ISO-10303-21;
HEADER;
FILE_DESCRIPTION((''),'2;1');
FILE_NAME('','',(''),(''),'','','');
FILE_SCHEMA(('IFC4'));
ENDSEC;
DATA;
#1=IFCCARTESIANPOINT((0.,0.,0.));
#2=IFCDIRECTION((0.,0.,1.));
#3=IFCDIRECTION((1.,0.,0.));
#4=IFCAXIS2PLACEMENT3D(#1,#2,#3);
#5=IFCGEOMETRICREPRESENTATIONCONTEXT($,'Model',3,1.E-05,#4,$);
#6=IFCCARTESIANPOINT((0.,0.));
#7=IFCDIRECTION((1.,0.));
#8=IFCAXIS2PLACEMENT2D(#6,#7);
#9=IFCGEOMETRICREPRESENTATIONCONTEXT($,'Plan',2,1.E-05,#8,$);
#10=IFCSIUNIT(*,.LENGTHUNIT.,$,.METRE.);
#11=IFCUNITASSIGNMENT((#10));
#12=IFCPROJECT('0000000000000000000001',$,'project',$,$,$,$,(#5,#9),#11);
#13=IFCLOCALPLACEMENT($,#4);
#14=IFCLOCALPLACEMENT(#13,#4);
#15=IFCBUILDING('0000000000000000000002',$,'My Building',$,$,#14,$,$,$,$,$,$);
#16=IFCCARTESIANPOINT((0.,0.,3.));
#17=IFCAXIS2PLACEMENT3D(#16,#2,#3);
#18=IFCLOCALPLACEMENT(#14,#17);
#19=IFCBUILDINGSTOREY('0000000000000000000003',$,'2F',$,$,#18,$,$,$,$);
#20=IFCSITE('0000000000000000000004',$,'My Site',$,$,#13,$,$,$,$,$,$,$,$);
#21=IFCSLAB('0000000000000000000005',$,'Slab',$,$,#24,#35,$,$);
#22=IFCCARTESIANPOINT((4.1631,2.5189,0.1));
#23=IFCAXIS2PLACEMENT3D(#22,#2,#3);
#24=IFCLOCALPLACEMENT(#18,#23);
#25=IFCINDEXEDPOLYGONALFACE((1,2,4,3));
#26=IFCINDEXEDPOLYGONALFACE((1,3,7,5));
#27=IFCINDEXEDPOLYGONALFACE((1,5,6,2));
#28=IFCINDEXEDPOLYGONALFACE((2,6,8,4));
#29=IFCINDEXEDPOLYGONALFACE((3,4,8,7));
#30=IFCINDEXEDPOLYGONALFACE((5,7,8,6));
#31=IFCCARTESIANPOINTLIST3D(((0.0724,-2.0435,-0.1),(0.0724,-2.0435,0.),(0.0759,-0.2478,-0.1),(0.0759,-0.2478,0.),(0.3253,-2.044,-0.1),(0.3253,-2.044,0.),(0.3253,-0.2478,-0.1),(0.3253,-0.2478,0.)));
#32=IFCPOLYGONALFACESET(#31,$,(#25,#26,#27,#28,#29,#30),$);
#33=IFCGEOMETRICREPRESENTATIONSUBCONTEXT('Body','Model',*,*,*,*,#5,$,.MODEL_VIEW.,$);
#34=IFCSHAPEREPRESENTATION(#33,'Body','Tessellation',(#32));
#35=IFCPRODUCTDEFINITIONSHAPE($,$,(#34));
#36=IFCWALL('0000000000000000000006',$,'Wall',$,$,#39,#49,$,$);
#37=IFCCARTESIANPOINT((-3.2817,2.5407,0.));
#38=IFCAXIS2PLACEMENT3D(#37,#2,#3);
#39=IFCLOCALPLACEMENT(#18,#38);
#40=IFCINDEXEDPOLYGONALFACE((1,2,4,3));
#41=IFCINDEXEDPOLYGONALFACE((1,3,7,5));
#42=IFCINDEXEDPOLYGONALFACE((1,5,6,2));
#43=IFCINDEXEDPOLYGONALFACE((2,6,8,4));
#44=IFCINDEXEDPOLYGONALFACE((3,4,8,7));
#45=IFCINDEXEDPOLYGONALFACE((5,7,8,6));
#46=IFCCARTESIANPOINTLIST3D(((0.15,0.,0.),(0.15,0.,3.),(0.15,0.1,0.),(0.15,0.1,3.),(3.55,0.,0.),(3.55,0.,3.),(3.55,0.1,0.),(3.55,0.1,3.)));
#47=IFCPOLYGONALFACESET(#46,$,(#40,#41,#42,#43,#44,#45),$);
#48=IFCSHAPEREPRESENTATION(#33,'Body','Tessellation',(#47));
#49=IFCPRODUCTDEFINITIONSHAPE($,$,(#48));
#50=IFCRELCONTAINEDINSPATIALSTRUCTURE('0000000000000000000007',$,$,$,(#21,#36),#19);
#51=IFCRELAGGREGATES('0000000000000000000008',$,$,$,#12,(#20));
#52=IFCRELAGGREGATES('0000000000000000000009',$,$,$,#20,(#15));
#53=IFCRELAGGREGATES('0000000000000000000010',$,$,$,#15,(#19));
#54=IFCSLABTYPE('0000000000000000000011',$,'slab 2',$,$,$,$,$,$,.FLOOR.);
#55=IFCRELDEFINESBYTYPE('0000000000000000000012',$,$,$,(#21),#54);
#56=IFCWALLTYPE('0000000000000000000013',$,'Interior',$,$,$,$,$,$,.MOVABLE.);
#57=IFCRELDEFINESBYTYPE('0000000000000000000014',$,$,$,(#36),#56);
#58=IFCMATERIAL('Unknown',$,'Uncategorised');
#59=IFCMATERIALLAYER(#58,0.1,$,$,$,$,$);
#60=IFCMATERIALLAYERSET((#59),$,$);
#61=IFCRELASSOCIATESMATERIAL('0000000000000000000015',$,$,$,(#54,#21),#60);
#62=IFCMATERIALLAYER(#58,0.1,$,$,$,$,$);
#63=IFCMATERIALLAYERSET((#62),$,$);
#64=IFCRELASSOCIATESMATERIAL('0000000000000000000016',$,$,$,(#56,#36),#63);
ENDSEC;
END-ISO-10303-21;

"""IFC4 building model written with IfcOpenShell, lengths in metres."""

from ifc_helpers import new_model, si_unit, frame, origin_with_axes, origin_2d_with_axis, place, context, subcontext, project, spatial, line, indexed_curve, outline, extrude, material, layer, layer_set, layer_usage, type_object, element, save


model = new_model("IFC4")

# Units and contexts
model_context = context("Model", 3, precision=1e-05, world=origin_with_axes())
plan_context = context("Plan", 2, precision=1e-05, world=origin_2d_with_axis())
body_context_1 = subcontext(model_context, "Body", "Model", "MODEL_VIEW")
ifc_project = project(units=[si_unit("LENGTHUNIT", "METRE")], contexts=[model_context, plan_context])

# Site, building, storey
site_placement = place(None, origin_with_axes())
site = spatial("IfcSite", under=ifc_project, at=site_placement, Name="My Site")
building_placement = place(site_placement, origin_with_axes())
building = spatial("IfcBuilding", under=site, at=building_placement, Name="My Building")
storey_placement = place(building_placement, frame((0.0, 0.0, 3.0), z_axis=(0.0, 0.0, 1.0), x_axis=(1.0, 0.0, 0.0)))
storey = spatial("IfcBuildingStorey", under=building, at=storey_placement, Name="2F")

# Shared definitions
ifc_material = material(Name="Unknown", Category="Uncategorised")

# Slab
ifc_layer_1 = layer(ifc_material, 0.1)
ifc_layer_set_1 = layer_set([ifc_layer_1])
ifc_layer_usage_1 = layer_usage(ifc_layer_set_1, "AXIS3", "POSITIVE", -0.1)
slab_type = type_object("IfcSlabType", Name="slab 2", PredefinedType="FLOOR", material=ifc_layer_set_1)
slab_placement = place(storey_placement, frame((4.1631, 2.5189, 0.1), z_axis=(0.0, 0.0, 1.0), x_axis=(1.0, 0.0, 0.0)))
element("IfcSlab", 1, at=slab_placement, inside=storey, type_object=slab_type, material=ifc_layer_usage_1, Name="Slab", context=body_context_1, shape_type="SweptSolid", body=[
    extrude(outline(indexed_curve([(0.0724, -2.0435), (0.3253, -2.044), (0.3253, -0.2478), (0.0759, -0.2478), (0.0724, -2.0435)])), frame((0.0, 0.0, -0.1), z_axis=(0.0, 0.0, 1.0), x_axis=(1.0, 0.0, 0.0)), (0.0, 0.0, 1.0), 0.1),
])

# Shared definitions
ifc_layer_2 = layer(ifc_material, 0.1)
ifc_layer_set_2 = layer_set([ifc_layer_2])
wall_type_1 = type_object("IfcWallType", Name="Interior", PredefinedType="MOVABLE", material=ifc_layer_set_2)

# Wall
ifc_layer_usage_2 = layer_usage(ifc_layer_set_2, "AXIS2", "POSITIVE", 0.0)
wall_1_placement = place(storey_placement, frame((-3.2817, 2.5407, 0.0), z_axis=(0.0, 0.0, 1.0), x_axis=(1.0, 0.0, 0.0)))
element("IfcWall", 2, at=wall_1_placement, inside=storey, type_object=wall_type_1, material=ifc_layer_usage_2, Name="Wall", context=body_context_1, shape_type="SweptSolid", body=[
    extrude(outline(indexed_curve([(0.15, 0.0), (0.15, 0.1), (3.55, 0.1), (3.55, 0.0)], segments=[line(1, 2, 3, 4, 1)])), origin_with_axes(), (0.0, 0.0, 1.0), 3.0),
])

save(model, "model.ifc")
